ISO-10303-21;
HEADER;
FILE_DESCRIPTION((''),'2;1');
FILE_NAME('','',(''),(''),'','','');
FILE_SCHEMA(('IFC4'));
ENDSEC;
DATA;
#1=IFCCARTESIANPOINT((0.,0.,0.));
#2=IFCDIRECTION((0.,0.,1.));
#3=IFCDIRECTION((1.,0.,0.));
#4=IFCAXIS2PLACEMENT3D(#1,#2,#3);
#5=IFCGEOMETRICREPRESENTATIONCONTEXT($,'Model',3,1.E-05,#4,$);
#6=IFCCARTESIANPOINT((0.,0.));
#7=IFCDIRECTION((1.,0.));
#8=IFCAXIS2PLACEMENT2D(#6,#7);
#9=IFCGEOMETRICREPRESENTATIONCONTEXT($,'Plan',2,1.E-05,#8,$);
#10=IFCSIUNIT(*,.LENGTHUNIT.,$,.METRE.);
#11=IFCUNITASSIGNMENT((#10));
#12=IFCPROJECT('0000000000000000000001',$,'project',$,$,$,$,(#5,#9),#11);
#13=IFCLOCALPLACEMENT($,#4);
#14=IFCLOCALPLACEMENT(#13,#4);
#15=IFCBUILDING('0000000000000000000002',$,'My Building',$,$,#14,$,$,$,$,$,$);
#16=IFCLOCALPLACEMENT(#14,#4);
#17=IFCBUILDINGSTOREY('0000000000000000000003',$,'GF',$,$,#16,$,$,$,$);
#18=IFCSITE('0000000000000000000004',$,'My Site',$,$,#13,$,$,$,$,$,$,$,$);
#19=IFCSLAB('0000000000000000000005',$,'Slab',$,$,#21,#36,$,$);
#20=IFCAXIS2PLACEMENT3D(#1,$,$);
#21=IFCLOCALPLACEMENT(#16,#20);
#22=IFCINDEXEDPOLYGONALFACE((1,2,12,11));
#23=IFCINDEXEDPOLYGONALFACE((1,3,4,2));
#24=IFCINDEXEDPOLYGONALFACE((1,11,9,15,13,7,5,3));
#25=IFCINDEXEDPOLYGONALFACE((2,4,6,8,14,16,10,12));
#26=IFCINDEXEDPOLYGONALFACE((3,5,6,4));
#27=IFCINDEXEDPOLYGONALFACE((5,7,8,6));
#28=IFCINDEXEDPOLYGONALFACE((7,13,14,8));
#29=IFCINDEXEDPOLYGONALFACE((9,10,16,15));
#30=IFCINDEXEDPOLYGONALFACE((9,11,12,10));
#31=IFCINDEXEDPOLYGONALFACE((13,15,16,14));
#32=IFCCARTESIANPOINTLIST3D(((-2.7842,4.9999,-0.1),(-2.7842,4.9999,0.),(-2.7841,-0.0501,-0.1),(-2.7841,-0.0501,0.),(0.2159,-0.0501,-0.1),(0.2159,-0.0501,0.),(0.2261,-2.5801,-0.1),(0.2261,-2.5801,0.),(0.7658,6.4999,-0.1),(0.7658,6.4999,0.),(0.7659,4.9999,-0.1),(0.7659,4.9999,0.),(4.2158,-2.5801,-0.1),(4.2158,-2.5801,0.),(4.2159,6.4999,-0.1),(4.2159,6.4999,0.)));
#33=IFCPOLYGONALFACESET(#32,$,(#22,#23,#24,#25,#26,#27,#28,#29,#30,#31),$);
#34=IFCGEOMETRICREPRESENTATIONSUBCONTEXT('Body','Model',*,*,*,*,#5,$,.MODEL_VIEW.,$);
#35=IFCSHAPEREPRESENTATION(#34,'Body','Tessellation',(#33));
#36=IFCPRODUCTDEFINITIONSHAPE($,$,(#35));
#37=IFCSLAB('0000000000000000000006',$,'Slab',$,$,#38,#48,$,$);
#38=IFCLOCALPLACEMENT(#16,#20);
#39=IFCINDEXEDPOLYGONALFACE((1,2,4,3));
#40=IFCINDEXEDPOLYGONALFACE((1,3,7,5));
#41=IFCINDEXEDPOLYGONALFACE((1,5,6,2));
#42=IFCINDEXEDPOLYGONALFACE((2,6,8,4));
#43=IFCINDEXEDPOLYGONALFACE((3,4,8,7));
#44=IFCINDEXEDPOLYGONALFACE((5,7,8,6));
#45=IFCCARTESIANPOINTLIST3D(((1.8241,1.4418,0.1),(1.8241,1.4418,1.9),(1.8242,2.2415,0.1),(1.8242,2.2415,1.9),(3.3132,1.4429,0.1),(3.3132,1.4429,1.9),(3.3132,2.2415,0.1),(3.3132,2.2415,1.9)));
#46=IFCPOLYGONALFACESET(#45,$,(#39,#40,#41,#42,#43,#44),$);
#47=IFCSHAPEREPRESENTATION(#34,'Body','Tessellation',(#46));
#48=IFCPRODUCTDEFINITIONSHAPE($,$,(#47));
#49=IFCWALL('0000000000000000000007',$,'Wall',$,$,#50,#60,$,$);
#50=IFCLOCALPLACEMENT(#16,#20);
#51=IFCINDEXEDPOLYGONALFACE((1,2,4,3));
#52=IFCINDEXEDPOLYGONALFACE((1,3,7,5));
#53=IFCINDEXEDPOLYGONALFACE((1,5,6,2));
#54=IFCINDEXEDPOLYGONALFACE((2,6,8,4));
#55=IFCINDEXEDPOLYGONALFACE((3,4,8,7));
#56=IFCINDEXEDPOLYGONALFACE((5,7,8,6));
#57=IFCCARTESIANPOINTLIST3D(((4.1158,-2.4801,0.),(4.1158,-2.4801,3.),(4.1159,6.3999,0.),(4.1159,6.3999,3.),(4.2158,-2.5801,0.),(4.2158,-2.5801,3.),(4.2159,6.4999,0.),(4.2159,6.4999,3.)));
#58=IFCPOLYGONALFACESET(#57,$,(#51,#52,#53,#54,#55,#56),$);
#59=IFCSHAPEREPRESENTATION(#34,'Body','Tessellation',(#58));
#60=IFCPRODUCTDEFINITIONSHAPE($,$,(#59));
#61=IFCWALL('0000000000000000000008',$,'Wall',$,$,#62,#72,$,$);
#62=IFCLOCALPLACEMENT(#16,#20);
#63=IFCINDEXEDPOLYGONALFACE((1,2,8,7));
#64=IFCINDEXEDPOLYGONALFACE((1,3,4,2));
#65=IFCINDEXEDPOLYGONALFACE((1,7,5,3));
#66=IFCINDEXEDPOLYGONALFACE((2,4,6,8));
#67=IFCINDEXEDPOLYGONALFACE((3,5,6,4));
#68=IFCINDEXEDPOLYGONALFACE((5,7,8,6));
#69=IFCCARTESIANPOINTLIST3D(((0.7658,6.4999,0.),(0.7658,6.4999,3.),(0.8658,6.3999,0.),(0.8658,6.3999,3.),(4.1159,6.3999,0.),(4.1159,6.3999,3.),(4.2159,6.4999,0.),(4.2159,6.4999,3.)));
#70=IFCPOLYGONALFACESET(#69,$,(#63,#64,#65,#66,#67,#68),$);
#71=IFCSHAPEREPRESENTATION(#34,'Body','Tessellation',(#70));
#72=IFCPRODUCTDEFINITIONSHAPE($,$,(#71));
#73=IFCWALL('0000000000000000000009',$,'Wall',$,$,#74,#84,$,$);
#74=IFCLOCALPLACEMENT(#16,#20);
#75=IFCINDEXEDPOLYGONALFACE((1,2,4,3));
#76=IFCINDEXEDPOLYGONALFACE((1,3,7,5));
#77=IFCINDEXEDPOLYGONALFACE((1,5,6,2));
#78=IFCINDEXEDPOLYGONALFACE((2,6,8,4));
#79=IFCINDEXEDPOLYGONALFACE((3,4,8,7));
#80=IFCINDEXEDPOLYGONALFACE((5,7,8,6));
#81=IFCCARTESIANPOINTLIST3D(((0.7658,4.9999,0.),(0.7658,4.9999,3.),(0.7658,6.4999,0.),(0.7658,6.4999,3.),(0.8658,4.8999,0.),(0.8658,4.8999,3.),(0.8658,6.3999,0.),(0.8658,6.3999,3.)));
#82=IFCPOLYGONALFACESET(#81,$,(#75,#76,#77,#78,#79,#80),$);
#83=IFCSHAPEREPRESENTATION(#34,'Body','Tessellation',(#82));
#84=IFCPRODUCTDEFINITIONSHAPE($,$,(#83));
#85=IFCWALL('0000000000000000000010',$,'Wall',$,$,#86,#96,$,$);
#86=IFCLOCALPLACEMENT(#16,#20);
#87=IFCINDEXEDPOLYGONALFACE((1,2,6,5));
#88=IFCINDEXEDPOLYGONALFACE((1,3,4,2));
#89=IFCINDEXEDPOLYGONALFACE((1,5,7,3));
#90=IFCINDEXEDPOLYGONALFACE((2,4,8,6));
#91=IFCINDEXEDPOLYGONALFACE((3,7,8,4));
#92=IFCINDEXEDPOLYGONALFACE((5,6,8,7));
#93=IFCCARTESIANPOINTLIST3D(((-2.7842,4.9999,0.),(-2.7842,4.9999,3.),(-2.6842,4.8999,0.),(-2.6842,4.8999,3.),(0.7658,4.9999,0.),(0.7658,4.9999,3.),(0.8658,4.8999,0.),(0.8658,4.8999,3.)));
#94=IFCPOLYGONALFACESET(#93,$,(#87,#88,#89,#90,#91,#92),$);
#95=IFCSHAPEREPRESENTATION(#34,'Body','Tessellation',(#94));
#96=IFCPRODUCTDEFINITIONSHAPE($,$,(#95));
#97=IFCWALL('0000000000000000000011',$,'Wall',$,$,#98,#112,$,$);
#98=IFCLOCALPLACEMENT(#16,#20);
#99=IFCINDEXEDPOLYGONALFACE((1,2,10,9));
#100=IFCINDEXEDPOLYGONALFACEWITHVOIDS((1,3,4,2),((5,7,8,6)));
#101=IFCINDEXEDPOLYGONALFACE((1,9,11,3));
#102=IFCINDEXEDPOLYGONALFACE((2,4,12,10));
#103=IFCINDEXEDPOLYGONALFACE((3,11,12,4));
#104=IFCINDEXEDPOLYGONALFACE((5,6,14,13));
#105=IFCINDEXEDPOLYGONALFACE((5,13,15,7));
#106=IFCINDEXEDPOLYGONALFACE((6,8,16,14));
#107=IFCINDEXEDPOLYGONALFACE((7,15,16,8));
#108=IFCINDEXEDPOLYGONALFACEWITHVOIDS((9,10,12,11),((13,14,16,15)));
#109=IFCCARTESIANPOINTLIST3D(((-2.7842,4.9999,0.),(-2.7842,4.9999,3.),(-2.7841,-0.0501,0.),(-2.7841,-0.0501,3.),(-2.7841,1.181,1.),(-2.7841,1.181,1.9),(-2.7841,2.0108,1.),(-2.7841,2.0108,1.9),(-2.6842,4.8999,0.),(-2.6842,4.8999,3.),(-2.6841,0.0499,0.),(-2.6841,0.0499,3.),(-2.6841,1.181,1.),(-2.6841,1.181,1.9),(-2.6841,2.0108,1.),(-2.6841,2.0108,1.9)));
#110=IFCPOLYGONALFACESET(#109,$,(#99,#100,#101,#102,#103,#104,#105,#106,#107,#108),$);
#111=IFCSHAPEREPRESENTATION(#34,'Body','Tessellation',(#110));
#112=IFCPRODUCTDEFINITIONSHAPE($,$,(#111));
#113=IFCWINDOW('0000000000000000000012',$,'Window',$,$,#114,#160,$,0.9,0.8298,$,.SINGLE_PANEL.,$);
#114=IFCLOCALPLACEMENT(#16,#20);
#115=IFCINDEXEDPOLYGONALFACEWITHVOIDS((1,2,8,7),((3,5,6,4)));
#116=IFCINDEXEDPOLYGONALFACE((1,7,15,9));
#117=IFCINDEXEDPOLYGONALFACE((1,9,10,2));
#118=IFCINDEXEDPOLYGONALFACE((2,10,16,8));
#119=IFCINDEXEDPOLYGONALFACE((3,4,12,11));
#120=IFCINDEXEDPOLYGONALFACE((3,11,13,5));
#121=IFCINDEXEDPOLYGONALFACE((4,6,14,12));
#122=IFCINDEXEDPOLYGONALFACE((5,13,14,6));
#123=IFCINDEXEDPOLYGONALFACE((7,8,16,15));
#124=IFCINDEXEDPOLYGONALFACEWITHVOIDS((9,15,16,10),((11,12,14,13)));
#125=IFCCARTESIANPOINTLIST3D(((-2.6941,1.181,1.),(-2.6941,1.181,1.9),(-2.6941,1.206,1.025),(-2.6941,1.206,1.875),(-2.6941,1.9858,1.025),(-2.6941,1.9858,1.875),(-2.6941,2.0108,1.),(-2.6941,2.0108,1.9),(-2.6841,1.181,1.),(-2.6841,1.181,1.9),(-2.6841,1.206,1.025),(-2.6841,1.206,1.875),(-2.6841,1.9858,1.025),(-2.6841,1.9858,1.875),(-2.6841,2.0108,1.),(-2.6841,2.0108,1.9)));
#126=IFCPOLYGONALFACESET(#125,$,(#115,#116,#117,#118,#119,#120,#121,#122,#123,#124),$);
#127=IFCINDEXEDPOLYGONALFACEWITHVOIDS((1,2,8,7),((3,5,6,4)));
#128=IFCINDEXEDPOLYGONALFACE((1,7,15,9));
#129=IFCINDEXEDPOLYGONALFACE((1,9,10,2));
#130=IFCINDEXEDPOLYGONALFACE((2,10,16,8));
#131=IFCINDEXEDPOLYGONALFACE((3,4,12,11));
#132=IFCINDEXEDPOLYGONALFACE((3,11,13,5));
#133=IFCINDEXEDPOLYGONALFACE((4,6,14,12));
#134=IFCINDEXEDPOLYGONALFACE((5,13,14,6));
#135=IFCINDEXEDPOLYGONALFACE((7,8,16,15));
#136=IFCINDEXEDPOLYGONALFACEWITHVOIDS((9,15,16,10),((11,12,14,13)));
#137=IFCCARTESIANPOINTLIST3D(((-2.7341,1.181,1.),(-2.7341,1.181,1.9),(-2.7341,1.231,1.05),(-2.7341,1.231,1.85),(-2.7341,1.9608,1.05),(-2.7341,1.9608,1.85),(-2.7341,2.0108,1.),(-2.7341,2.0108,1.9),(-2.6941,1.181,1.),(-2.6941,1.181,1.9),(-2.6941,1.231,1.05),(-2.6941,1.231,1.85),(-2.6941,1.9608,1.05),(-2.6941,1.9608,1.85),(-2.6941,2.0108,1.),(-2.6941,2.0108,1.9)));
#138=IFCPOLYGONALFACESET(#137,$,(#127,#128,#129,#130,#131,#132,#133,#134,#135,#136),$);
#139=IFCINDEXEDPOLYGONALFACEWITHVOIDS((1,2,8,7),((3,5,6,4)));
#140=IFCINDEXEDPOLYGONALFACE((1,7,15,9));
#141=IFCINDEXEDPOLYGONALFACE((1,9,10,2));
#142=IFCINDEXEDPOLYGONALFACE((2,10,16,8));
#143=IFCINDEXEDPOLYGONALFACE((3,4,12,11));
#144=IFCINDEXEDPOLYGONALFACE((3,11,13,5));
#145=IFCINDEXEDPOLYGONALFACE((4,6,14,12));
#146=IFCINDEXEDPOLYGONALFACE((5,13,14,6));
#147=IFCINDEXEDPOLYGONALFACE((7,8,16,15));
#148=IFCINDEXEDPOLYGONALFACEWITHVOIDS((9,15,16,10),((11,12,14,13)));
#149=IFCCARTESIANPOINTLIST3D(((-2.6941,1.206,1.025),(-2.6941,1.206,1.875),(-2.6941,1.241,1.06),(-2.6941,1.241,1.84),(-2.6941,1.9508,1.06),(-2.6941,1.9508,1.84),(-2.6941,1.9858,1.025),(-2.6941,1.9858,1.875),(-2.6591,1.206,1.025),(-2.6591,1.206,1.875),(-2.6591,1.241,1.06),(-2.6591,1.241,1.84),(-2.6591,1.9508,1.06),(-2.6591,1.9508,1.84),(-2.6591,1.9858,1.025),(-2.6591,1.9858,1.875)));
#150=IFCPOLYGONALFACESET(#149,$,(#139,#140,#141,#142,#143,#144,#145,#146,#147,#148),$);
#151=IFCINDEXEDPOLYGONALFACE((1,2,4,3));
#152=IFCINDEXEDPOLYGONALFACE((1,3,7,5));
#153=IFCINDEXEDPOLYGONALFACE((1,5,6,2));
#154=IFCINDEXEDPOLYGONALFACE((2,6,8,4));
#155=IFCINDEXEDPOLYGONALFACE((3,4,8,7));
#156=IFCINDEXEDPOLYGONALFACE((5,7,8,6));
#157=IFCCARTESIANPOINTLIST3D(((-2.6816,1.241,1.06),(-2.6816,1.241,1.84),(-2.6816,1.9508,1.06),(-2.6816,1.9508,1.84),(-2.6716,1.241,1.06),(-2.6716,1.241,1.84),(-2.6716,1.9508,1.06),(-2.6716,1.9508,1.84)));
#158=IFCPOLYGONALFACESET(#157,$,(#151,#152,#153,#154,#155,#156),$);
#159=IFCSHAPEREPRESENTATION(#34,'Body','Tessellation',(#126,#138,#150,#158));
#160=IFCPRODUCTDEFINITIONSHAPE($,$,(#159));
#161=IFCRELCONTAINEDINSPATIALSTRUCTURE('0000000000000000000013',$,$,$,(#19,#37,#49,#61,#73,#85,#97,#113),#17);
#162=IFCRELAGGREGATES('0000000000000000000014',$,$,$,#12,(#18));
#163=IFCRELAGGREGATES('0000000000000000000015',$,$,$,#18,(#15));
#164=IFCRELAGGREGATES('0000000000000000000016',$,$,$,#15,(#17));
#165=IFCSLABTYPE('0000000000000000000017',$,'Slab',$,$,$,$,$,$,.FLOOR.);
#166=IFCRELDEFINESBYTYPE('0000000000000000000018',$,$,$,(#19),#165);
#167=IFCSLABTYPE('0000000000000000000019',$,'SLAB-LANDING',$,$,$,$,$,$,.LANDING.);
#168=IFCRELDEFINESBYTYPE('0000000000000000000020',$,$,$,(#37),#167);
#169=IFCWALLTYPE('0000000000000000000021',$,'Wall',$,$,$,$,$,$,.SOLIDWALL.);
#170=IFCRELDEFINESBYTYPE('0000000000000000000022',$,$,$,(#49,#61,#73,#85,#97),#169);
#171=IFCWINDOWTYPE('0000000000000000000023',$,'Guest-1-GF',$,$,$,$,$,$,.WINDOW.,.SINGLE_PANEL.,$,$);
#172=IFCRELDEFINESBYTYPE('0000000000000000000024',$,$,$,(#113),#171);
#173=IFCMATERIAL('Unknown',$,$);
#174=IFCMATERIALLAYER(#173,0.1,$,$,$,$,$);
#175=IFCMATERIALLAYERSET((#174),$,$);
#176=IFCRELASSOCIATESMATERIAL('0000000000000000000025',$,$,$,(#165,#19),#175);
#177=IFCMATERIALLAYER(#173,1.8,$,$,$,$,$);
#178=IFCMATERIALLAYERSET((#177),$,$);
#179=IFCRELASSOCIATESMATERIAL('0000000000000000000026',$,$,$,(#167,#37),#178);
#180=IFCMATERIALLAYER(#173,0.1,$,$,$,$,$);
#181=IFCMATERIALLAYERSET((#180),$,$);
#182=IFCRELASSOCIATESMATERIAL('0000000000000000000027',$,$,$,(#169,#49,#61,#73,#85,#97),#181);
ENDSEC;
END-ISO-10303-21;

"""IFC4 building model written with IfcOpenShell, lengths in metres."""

from ifc_helpers import new_model, entity, si_unit, frame, origin_with_axes, origin_2d_with_axis, place, context, subcontext, project, spatial, line, indexed_curve, outline, extrude, shape, source, transform, mapped, material, layer, layer_set, layer_usage, type_object, type_shapes, element, fill, save


model = new_model("IFC4")

# Units and contexts
model_context = context("Model", 3, precision=1e-05, world=origin_with_axes())
plan_context = context("Plan", 2, precision=1e-05, world=origin_2d_with_axis())
body_context_1 = subcontext(model_context, "Body", "Model", "MODEL_VIEW")
body_context_2 = subcontext(plan_context, "Body", "Plan", "PLAN_VIEW")
ifc_project = project(units=[si_unit("LENGTHUNIT", "METRE")], contexts=[model_context, plan_context])

# Site, building, storey
site_placement = place(None, origin_with_axes())
site = spatial("IfcSite", under=ifc_project, at=site_placement, Name="My Site")
building_placement = place(site_placement, origin_with_axes())
building = spatial("IfcBuilding", under=site, at=building_placement, Name="My Building")
storey_placement = place(building_placement, origin_with_axes())
storey = spatial("IfcBuildingStorey", under=building, at=storey_placement, Name="GF")

# Slabs
ifc_material_1 = material(Name="Unknown")
ifc_layer_1 = layer(ifc_material_1, 0.1)
ifc_layer_set_1 = layer_set([ifc_layer_1])
ifc_layer_usage_1 = layer_usage(ifc_layer_set_1, "AXIS3", "POSITIVE", -0.1)
slab_type_1 = type_object("IfcSlabType", Name="Slab", PredefinedType="FLOOR", material=ifc_layer_set_1)
slab_1_placement = place(storey_placement, frame((0.2261, -2.5801, 0.0), z_axis=(0.0, 0.0, 1.0), x_axis=(1.0, 0.0, 0.0)))
element("IfcSlab", 1, at=slab_1_placement, inside=storey, type_object=slab_type_1, material=ifc_layer_usage_1, Name="Slab", context=body_context_1, shape_type="SweptSolid", body=[
    extrude(outline(indexed_curve([(0.0, 0.0), (3.9897, 0.0), (3.9897, 9.08), (0.5397, 9.08), (0.5397, 7.58), (-3.0103, 7.58), (-3.0103, 2.53), (-0.0103, 2.53), (0.0, 0.0)])), frame((0.0, 0.0, -0.1), z_axis=(0.0, 0.0, 1.0), x_axis=(1.0, 0.0, 0.0)), (0.0, 0.0, 1.0), 0.1),
])
ifc_layer_2 = layer(ifc_material_1, 1.8)
ifc_layer_set_2 = layer_set([ifc_layer_2])
slab_type_2 = type_object("IfcSlabType", Name="SLAB-LANDING", PredefinedType="LANDING", material=ifc_layer_set_2)
ifc_layer_usage_2 = layer_usage(ifc_layer_set_2, "AXIS3", "POSITIVE", -1.8)
slab_2_placement = place(storey_placement, frame((1.8241, 1.4418, 1.9), z_axis=(0.0, 0.0, 1.0), x_axis=(1.0, 0.0, 0.0)))
element("IfcSlab", 2, at=slab_2_placement, inside=storey, type_object=slab_type_2, material=ifc_layer_usage_2, Name="Slab", context=body_context_1, shape_type="SweptSolid", body=[
    extrude(outline(indexed_curve([(0.0, 0.0), (1.489, 0.0011), (1.489, 0.7997), (0.0, 0.7997), (0.0, 0.0)])), frame((0.0, 0.0, -1.8), z_axis=(0.0, 0.0, 1.0), x_axis=(1.0, 0.0, 0.0)), (0.0, 0.0, 1.0), 1.8),
])

# Shared definitions
ifc_layer_3 = layer(ifc_material_1, 0.1)
ifc_layer_set_3 = layer_set([ifc_layer_3])
wall_type = type_object("IfcWallType", Name="Wall", PredefinedType="SOLIDWALL", material=ifc_layer_set_3)

# Walls
ifc_layer_usage_3 = layer_usage(ifc_layer_set_3, "AXIS2", "POSITIVE", 0.0)
wall_1_placement = place(storey_placement, frame((4.2158, -2.5801, 0.0), z_axis=(0.0, 0.0, 1.0), x_axis=(0.0, 1.0, 0.0)))
element("IfcWall", 3, at=wall_1_placement, inside=storey, type_object=wall_type, material=ifc_layer_usage_3, Name="Wall", context=body_context_1, shape_type="SweptSolid", body=[
    extrude(outline(indexed_curve([(0.0, 0.0), (0.1, 0.1), (8.98, 0.1), (9.08, 0.0)], segments=[line(1, 2, 3, 4, 1)])), origin_with_axes(), (0.0, 0.0, 1.0), 3.0),
])
ifc_layer_usage_4 = layer_usage(ifc_layer_set_3, "AXIS2", "POSITIVE", 0.0)
wall_2_placement = place(storey_placement, frame((4.2159, 6.4999, 0.0), z_axis=(0.0, 0.0, 1.0), x_axis=(-1.0, 0.0, 0.0)))
element("IfcWall", 4, at=wall_2_placement, inside=storey, type_object=wall_type, material=ifc_layer_usage_4, Name="Wall", context=body_context_1, shape_type="SweptSolid", body=[
    extrude(outline(indexed_curve([(0.0, 0.0), (0.1, 0.1), (3.35, 0.1), (3.45, 0.0)], segments=[line(1, 2, 3, 4, 1)])), origin_with_axes(), (0.0, 0.0, 1.0), 3.0),
])
ifc_layer_usage_5 = layer_usage(ifc_layer_set_3, "AXIS2", "POSITIVE", 0.0)
wall_3_placement = place(storey_placement, frame((0.7658, 6.4999, 0.0), z_axis=(0.0, 0.0, 1.0), x_axis=(0.0, -1.0, 0.0)))
element("IfcWall", 5, at=wall_3_placement, inside=storey, type_object=wall_type, material=ifc_layer_usage_5, Name="Wall", context=body_context_1, shape_type="SweptSolid", body=[
    extrude(outline(indexed_curve([(0.0, 0.0), (0.1, 0.1), (1.6, 0.1), (1.5, 0.0)], segments=[line(1, 2, 3, 4, 1)])), origin_with_axes(), (0.0, 0.0, 1.0), 3.0),
])
ifc_layer_usage_6 = layer_usage(ifc_layer_set_3, "AXIS2", "POSITIVE", 0.0)
wall_4_placement = place(storey_placement, frame((0.7658, 4.9999, 0.0), z_axis=(0.0, 0.0, 1.0), x_axis=(-1.0, 0.0, 0.0)))
element("IfcWall", 6, at=wall_4_placement, inside=storey, type_object=wall_type, material=ifc_layer_usage_6, Name="Wall", context=body_context_1, shape_type="SweptSolid", body=[
    extrude(outline(indexed_curve([(0.0, 0.0), (-0.1, 0.1), (3.45, 0.1), (3.55, 0.0)], segments=[line(1, 2, 3, 4, 1)])), origin_with_axes(), (0.0, 0.0, 1.0), 3.0),
])

# Wall, opening, window
ifc_layer_usage_7 = layer_usage(ifc_layer_set_3, "AXIS2", "POSITIVE", 0.0)
wall_5_placement = place(storey_placement, frame((-2.7842, 4.9999, 0.0), z_axis=(0.0, 0.0, 1.0), x_axis=(0.0, -1.0, 0.0)))
wall_5 = element("IfcWall", 7, at=wall_5_placement, inside=storey, type_object=wall_type, material=ifc_layer_usage_7, Name="Wall", context=body_context_1, shape_type="SweptSolid", body=[
    extrude(outline(indexed_curve([(0.0, 0.0), (0.1, 0.1), (4.95, 0.1), (5.05, 0.0)], segments=[line(1, 2, 3, 4, 1)])), origin_with_axes(), (0.0, 0.0, 1.0), 3.0),
])
shared_shape_1 = source(origin_with_axes(), body_context_1, "Body", "SweptSolid", [
    extrude(outline(indexed_curve([(0.0, 0.0), (0.8298, 0.0), (0.8298, 0.9), (0.0, 0.9)], segments=[line(1, 2, 3, 4, 1)])), frame((0.0, -0.6, 0.0), z_axis=(0.0, -1.0, 0.0), x_axis=(1.0, 0.0, 0.0)), (0.0, 0.0, -1.0), 1.2),
])
opening_1_placement = place(wall_5_placement, frame((2.989, 0.0, 1.0), z_axis=(0.0, 0.0, 1.0), x_axis=(1.0, 0.0, 0.0)))
opening_1 = element("IfcOpeningElement", 8, at=opening_1_placement, cuts=wall_5, PredefinedType="OPENING", context=body_context_1, shape_type="MappedRepresentation", body=[
    mapped(shared_shape_1, transform((0.0, 0.0, 0.0), x_axis=(1.0, 0.0, 0.0), y_axis=(0.0, 1.0, 0.0), z_axis=(0.0, 0.0, 1.0), scale=1.0)),
])
window_type_1 = type_object("IfcWindowType", Name="Guest-1-GF", PartitioningType="SINGLE_PANEL", PredefinedType="WINDOW")
shared_shape_2 = source(origin_with_axes(), body_context_1, "Body", "SweptSolid", [
    extrude(outline(indexed_curve([(0.0, 0.0), (0.8298, 0.0), (0.8298, 0.9), (0.0, 0.9)], segments=[line(1, 2, 3, 4, 1)]), holes=[indexed_curve([(0.025, 0.025), (0.8048, 0.025), (0.8048, 0.875), (0.025, 0.875)], segments=[line(1, 2, 3, 4, 1)])]), frame((0.0, 0.09, 0.0), z_axis=(0.0, -1.0, 0.0), x_axis=(1.0, 0.0, 0.0)), (0.0, 0.0, -1.0), 0.01),
    extrude(outline(indexed_curve([(0.0, 0.0), (0.8298, 0.0), (0.8298, 0.9), (0.0, 0.9)], segments=[line(1, 2, 3, 4, 1)]), holes=[indexed_curve([(0.05, 0.05), (0.7798, 0.05), (0.7798, 0.85), (0.05, 0.85)], segments=[line(1, 2, 3, 4, 1)])]), frame((0.0, 0.05, 0.0), z_axis=(0.0, -1.0, 0.0), x_axis=(1.0, 0.0, 0.0)), (0.0, 0.0, -1.0), 0.04),
    extrude(outline(indexed_curve([(0.0, 0.0), (0.7798, 0.0), (0.7798, 0.85), (0.0, 0.85)], segments=[line(1, 2, 3, 4, 1)]), holes=[indexed_curve([(0.035, 0.035), (0.7448, 0.035), (0.7448, 0.815), (0.035, 0.815)], segments=[line(1, 2, 3, 4, 1)])]), frame((0.025, 0.09, 0.025), z_axis=(0.0, -1.0, 0.0), x_axis=(1.0, 0.0, 0.0)), (0.0, 0.0, -1.0), 0.035),
    extrude(outline(indexed_curve([(0.035, 0.035), (0.7448, 0.035), (0.7448, 0.815), (0.035, 0.815)], segments=[line(1, 2, 3, 4, 1)])), frame((0.025, 0.1025, 0.025), z_axis=(0.0, -1.0, 0.0), x_axis=(1.0, 0.0, 0.0)), (0.0, 0.0, -1.0), 0.01),
])
shared_shape_3 = source(origin_with_axes(), body_context_2, "Body", "Curve2D", [
    entity("IfcIndexedPolyCurve", entity("IfcCartesianPointList2D", [[0.05, 0.05], [0.7798, 0.05]])),
    entity("IfcIndexedPolyCurve", entity("IfcCartesianPointList2D", [[0.0, 0.1], [0.025, 0.1], [0.025, 0.09], [0.05, 0.09], [0.05, 0.05], [0.0, 0.05]]), [entity("IfcLineIndex", [1, 2, 3, 4, 5, 6, 1])]),
    entity("IfcIndexedPolyCurve", entity("IfcCartesianPointList2D", [[0.8298, 0.1], [0.8048, 0.1], [0.8048, 0.09], [0.7798, 0.09], [0.7798, 0.05], [0.8298, 0.05]]), [entity("IfcLineIndex", [1, 2, 3, 4, 5, 6, 1])]),
    entity("IfcIndexedPolyCurve", entity("IfcCartesianPointList2D", [[0.025, 0.09], [0.06, 0.09], [0.06, 0.125], [0.025, 0.125]]), [entity("IfcLineIndex", [1, 2, 3, 4, 1])]),
    entity("IfcIndexedPolyCurve", entity("IfcCartesianPointList2D", [[0.8048, 0.09], [0.7698, 0.09], [0.7698, 0.125], [0.8048, 0.125]]), [entity("IfcLineIndex", [1, 2, 3, 4, 1])]),
    entity("IfcIndexedPolyCurve", entity("IfcCartesianPointList2D", [[0.06, 0.09], [0.7698, 0.09]])),
    entity("IfcIndexedPolyCurve", entity("IfcCartesianPointList2D", [[0.06, 0.125], [0.7698, 0.125]])),
    entity("IfcIndexedPolyCurve", entity("IfcCartesianPointList2D", [[0.06, 0.1075], [0.7698, 0.1075]])),
])
type_shapes(window_type_1, [shared_shape_2, shared_shape_3])
window_1_placement = place(opening_1_placement, frame((0.0, 0.0, 0.0), z_axis=(0.0, 0.0, 1.0), x_axis=(1.0, 0.0, 0.0)))
window_1 = element("IfcWindow", 9, at=window_1_placement, inside=storey, type_object=window_type_1, Name="Window", OverallHeight=0.9, OverallWidth=0.8298, PartitioningType="SINGLE_PANEL", shapes=[
    shape(body_context_1, "Body", "MappedRepresentation", [mapped(shared_shape_2, transform((0.0, 0.0, 0.0), x_axis=(1.0, 0.0, 0.0), y_axis=(0.0, 1.0, 0.0), z_axis=(0.0, 0.0, 1.0), scale=1.0))]),
    shape(body_context_2, "Body", "MappedRepresentation", [mapped(shared_shape_3, transform((0.0, 0.0, 0.0), x_axis=(1.0, 0.0, 0.0), y_axis=(0.0, 1.0, 0.0), z_axis=(0.0, 0.0, 1.0), scale=1.0))]),
])
fill(opening_1, window_1)

save(model, "model.ifc")
